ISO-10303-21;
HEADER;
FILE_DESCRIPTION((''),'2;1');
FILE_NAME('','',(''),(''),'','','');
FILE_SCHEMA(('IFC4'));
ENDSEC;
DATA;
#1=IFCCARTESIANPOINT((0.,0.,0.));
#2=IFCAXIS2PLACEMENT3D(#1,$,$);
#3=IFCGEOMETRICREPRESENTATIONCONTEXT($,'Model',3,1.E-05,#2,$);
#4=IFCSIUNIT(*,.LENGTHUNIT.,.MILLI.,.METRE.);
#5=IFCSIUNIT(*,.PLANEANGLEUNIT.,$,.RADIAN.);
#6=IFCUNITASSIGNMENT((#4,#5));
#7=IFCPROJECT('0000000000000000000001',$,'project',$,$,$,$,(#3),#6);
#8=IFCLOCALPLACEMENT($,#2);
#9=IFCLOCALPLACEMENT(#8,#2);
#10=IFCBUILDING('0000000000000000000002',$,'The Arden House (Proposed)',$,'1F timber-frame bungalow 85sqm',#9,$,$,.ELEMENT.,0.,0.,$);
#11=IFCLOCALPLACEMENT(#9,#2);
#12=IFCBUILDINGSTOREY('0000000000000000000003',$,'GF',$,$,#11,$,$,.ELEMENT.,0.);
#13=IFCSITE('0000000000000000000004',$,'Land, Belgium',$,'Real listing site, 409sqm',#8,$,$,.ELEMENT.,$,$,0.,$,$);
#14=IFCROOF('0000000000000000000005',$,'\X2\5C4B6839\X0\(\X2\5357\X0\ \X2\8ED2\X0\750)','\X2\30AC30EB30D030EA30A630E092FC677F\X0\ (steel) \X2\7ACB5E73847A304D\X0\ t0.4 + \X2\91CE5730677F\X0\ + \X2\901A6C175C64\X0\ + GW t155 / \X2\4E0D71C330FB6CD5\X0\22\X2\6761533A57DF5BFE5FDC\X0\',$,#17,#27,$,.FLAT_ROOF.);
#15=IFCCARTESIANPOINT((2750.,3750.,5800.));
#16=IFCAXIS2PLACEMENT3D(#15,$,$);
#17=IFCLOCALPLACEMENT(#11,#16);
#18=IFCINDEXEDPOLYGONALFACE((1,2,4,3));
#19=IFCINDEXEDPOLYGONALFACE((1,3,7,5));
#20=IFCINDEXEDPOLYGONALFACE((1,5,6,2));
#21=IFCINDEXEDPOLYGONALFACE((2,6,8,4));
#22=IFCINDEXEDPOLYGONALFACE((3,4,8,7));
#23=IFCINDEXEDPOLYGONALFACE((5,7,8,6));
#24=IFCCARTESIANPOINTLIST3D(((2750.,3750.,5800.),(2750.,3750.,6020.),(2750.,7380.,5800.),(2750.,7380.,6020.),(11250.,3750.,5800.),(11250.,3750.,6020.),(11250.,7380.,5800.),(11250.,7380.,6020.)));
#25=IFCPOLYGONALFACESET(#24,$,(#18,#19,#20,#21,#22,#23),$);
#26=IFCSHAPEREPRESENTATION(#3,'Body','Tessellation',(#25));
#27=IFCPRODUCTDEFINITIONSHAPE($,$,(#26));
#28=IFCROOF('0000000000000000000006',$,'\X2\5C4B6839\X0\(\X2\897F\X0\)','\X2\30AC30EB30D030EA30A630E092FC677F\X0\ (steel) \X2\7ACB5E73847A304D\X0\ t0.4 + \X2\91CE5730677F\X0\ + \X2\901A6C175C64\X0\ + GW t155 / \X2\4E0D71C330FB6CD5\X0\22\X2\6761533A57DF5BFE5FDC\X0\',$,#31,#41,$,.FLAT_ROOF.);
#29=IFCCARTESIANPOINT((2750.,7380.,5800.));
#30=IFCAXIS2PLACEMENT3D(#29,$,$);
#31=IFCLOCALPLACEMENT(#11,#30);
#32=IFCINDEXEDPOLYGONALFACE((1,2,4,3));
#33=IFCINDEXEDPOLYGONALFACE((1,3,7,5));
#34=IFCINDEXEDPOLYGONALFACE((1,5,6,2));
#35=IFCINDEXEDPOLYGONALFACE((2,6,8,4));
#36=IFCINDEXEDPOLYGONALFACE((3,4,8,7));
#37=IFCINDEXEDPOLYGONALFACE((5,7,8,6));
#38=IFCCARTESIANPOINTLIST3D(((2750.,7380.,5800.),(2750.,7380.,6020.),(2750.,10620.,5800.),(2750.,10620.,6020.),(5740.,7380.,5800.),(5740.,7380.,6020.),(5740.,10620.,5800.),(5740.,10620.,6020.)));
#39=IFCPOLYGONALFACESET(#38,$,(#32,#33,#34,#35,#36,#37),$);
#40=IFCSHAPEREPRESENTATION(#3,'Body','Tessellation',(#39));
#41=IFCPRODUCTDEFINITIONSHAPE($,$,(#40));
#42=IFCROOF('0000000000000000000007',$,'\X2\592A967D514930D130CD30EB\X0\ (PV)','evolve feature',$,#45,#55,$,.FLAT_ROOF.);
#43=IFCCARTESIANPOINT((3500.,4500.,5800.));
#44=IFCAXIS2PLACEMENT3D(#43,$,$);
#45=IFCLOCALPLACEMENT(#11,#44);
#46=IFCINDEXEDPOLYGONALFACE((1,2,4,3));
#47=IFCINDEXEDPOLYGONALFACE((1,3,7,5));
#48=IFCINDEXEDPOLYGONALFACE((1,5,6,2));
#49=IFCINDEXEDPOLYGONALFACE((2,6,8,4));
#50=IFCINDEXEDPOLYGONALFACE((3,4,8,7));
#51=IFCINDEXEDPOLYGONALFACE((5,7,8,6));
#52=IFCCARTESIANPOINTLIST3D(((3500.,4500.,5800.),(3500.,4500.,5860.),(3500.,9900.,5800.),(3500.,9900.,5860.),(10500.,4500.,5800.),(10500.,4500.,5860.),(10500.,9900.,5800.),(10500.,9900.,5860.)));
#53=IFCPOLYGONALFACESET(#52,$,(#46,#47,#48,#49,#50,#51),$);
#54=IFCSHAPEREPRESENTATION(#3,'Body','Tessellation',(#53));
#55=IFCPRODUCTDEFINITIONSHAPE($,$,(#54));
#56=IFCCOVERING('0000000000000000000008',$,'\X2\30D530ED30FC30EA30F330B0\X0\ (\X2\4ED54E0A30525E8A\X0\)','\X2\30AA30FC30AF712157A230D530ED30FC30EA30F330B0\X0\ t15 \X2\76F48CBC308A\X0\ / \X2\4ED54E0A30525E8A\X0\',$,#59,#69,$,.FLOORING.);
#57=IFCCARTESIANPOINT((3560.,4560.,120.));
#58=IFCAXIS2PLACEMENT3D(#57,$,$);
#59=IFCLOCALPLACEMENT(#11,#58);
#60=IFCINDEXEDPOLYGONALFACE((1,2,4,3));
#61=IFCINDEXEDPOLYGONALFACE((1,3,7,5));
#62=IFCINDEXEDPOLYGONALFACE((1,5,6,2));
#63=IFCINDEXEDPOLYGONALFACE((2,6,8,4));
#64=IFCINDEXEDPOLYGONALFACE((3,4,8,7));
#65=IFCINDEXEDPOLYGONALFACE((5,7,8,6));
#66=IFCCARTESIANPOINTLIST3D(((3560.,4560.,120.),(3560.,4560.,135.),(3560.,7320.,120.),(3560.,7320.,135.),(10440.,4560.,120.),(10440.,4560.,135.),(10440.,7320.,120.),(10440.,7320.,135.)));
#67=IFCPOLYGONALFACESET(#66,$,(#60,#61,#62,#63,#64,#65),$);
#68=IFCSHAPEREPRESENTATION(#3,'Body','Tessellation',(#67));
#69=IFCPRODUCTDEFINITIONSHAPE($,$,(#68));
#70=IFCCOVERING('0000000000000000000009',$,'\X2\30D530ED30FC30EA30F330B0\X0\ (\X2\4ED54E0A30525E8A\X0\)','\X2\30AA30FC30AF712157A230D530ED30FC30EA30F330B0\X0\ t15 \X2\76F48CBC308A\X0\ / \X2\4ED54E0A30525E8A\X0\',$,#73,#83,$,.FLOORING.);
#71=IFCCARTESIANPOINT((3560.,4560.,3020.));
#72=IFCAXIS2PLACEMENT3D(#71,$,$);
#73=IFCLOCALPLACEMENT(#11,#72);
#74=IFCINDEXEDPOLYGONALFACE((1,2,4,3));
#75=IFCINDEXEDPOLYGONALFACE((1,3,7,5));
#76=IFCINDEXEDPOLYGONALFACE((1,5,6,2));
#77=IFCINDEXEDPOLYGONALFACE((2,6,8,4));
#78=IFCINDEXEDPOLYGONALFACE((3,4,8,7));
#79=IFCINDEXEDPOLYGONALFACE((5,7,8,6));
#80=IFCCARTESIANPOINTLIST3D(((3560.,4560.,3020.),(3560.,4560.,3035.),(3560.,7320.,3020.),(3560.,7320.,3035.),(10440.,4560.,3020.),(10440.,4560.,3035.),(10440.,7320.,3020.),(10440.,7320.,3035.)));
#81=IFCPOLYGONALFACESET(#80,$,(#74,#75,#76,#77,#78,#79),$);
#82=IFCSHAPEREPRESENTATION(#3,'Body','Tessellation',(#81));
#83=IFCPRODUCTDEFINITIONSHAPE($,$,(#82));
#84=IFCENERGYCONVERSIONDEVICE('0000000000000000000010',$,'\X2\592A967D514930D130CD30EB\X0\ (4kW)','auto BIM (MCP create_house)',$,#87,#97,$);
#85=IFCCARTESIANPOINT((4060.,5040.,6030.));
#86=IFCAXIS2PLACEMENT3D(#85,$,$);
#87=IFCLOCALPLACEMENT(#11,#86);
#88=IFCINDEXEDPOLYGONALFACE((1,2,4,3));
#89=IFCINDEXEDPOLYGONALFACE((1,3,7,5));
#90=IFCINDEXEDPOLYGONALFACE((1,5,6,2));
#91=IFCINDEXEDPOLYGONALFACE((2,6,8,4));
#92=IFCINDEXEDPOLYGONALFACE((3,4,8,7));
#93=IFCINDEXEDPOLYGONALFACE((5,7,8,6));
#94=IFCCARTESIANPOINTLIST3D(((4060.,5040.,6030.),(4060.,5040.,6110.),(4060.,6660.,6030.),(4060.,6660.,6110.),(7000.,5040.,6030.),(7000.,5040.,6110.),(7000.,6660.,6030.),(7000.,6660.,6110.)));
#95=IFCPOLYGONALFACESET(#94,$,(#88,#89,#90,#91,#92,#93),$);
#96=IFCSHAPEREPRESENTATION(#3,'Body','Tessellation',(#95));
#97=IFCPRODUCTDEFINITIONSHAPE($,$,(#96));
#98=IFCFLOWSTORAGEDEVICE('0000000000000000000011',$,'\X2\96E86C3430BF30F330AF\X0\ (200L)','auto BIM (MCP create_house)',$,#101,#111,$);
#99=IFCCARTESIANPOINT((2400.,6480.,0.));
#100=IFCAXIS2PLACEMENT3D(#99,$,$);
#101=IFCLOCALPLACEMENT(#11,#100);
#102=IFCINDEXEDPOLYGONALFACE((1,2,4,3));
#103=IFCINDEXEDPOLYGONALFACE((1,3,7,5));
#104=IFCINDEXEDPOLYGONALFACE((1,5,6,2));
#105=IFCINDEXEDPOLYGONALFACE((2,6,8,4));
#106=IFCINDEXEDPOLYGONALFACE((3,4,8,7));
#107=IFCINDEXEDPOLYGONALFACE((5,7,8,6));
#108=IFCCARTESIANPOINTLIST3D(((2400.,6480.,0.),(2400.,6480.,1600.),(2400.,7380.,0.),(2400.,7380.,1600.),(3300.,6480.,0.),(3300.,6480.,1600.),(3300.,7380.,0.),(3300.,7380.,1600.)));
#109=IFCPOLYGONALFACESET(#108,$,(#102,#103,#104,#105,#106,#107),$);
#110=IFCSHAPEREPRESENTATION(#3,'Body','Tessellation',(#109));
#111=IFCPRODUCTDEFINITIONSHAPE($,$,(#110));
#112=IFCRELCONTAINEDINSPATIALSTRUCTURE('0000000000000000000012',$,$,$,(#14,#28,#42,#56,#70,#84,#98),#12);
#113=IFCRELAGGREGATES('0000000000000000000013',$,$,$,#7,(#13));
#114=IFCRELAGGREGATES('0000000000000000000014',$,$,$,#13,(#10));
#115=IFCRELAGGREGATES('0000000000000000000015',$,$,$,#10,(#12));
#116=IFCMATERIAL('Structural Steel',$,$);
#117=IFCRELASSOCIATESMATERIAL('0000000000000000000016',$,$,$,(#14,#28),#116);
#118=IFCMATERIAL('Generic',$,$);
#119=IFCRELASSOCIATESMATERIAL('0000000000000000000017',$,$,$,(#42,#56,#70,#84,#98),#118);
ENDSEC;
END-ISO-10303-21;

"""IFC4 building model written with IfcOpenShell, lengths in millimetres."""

from ifc_helpers import new_model, si_unit, frame, frame_2d, origin, place, context, project, spatial, rectangle, extrude, material, element, save


model = new_model("IFC4")

# Units and contexts
model_context = context("Model", 3, precision=1e-05, world=origin())
ifc_project = project(units=[si_unit("LENGTHUNIT", "METRE", prefix="MILLI"), si_unit("PLANEANGLEUNIT", "RADIAN")], contexts=[model_context])

# Site, building, storey
site_placement = place(None, origin())
site = spatial("IfcSite", under=ifc_project, at=site_placement, Name="Land, Belgium", ObjectType="Real listing site, 409sqm", CompositionType="ELEMENT", RefElevation=0.0)
building_placement = place(site_placement, origin())
building = spatial("IfcBuilding", under=site, at=building_placement, Name="The Arden House (Proposed)", ObjectType="1F timber-frame bungalow 85sqm", CompositionType="ELEMENT", ElevationOfRefHeight=0.0, ElevationOfTerrain=0.0)
storey_placement = place(building_placement, origin())
storey = spatial("IfcBuildingStorey", under=building, at=storey_placement, Name="GF", CompositionType="ELEMENT", Elevation=0.0)

# Shared definitions
ifc_material_1 = material(Name="Generic")

# Roofs
ifc_material_2 = material(Name="Structural Steel")
roof_1_placement = place(storey_placement, frame((2750.0, 3750.0, 5800.0)))
element("IfcRoof", 1, at=roof_1_placement, inside=storey, material=ifc_material_2, Name="屋根(南 軒750)", Description="ガルバリウム鋼板 (steel) 立平葺き t0.4 + 野地板 + 通気層 + GW t155 / 不燃・法22条区域対応", PredefinedType="FLAT_ROOF", context=model_context, shape_type="SweptSolid", body=[
    extrude(rectangle(XDim=8500.0, YDim=3630.0, at=frame_2d((4250.0, 1815.0))), frame((2750.0, 3750.0, 5800.0)), (0.0, 0.0, 1.0), 220.0),
])
roof_2_placement = place(storey_placement, frame((2750.0, 7380.0, 5800.0)))
element("IfcRoof", 2, at=roof_2_placement, inside=storey, material=ifc_material_2, Name="屋根(西)", Description="ガルバリウム鋼板 (steel) 立平葺き t0.4 + 野地板 + 通気層 + GW t155 / 不燃・法22条区域対応", PredefinedType="FLAT_ROOF", context=model_context, shape_type="SweptSolid", body=[
    extrude(rectangle(XDim=2990.0, YDim=3240.0, at=frame_2d((1495.0, 1620.0))), frame((2750.0, 7380.0, 5800.0)), (0.0, 0.0, 1.0), 220.0),
])
roof_3_placement = place(storey_placement, frame((3500.0, 4500.0, 5800.0)))
element("IfcRoof", 3, at=roof_3_placement, inside=storey, material=ifc_material_1, Name="太陽光パネル (PV)", Description="evolve feature", PredefinedType="FLAT_ROOF", context=model_context, shape_type="SweptSolid", body=[
    extrude(rectangle(XDim=7000.0, YDim=5400.0, at=frame_2d((3500.0, 2700.0))), frame((3500.0, 4500.0, 5800.0)), (0.0, 0.0, 1.0), 60.0),
])

# Coverings
covering_1_placement = place(storey_placement, frame((3560.0, 4560.0, 120.0)))
element("IfcCovering", 4, at=covering_1_placement, inside=storey, material=ifc_material_1, Name="フローリング (仕上げ床)", Description="オーク無垢フローリング t15 直貼り / 仕上げ床", PredefinedType="FLOORING", context=model_context, shape_type="SweptSolid", body=[
    extrude(rectangle(XDim=6880.0, YDim=2760.0, at=frame_2d((3440.0, 1380.0))), frame((3560.0, 4560.0, 120.0)), (0.0, 0.0, 1.0), 15.0),
])
covering_2_placement = place(storey_placement, frame((3560.0, 4560.0, 3020.0)))
element("IfcCovering", 5, at=covering_2_placement, inside=storey, material=ifc_material_1, Name="フローリング (仕上げ床)", Description="オーク無垢フローリング t15 直貼り / 仕上げ床", PredefinedType="FLOORING", context=model_context, shape_type="SweptSolid", body=[
    extrude(rectangle(XDim=6880.0, YDim=2760.0, at=frame_2d((3440.0, 1380.0))), frame((3560.0, 4560.0, 3020.0)), (0.0, 0.0, 1.0), 15.0),
])

# Energy conversion device
energy_conversion_device_placement = place(storey_placement, frame((4060.0, 5040.0, 6030.0)))
element("IfcEnergyConversionDevice", 6, at=energy_conversion_device_placement, inside=storey, material=ifc_material_1, Name="太陽光パネル (4kW)", Description="auto BIM (MCP create_house)", context=model_context, shape_type="SweptSolid", body=[
    extrude(rectangle(XDim=2940.0, YDim=1620.0, at=frame_2d((1470.0, 810.0))), frame((4060.0, 5040.0, 6030.0)), (0.0, 0.0, 1.0), 80.0),
])

# Flow storage device
flow_storage_device_placement = place(storey_placement, frame((2400.0, 6480.0, 0.0)))
element("IfcFlowStorageDevice", 7, at=flow_storage_device_placement, inside=storey, material=ifc_material_1, Name="雨水タンク (200L)", Description="auto BIM (MCP create_house)", context=model_context, shape_type="SweptSolid", body=[
    extrude(rectangle(XDim=900.0, YDim=900.0, at=frame_2d((450.0, 450.0))), frame((2400.0, 6480.0, 0.0)), (0.0, 0.0, 1.0), 1600.0),
])

save(model, "model.ifc")
